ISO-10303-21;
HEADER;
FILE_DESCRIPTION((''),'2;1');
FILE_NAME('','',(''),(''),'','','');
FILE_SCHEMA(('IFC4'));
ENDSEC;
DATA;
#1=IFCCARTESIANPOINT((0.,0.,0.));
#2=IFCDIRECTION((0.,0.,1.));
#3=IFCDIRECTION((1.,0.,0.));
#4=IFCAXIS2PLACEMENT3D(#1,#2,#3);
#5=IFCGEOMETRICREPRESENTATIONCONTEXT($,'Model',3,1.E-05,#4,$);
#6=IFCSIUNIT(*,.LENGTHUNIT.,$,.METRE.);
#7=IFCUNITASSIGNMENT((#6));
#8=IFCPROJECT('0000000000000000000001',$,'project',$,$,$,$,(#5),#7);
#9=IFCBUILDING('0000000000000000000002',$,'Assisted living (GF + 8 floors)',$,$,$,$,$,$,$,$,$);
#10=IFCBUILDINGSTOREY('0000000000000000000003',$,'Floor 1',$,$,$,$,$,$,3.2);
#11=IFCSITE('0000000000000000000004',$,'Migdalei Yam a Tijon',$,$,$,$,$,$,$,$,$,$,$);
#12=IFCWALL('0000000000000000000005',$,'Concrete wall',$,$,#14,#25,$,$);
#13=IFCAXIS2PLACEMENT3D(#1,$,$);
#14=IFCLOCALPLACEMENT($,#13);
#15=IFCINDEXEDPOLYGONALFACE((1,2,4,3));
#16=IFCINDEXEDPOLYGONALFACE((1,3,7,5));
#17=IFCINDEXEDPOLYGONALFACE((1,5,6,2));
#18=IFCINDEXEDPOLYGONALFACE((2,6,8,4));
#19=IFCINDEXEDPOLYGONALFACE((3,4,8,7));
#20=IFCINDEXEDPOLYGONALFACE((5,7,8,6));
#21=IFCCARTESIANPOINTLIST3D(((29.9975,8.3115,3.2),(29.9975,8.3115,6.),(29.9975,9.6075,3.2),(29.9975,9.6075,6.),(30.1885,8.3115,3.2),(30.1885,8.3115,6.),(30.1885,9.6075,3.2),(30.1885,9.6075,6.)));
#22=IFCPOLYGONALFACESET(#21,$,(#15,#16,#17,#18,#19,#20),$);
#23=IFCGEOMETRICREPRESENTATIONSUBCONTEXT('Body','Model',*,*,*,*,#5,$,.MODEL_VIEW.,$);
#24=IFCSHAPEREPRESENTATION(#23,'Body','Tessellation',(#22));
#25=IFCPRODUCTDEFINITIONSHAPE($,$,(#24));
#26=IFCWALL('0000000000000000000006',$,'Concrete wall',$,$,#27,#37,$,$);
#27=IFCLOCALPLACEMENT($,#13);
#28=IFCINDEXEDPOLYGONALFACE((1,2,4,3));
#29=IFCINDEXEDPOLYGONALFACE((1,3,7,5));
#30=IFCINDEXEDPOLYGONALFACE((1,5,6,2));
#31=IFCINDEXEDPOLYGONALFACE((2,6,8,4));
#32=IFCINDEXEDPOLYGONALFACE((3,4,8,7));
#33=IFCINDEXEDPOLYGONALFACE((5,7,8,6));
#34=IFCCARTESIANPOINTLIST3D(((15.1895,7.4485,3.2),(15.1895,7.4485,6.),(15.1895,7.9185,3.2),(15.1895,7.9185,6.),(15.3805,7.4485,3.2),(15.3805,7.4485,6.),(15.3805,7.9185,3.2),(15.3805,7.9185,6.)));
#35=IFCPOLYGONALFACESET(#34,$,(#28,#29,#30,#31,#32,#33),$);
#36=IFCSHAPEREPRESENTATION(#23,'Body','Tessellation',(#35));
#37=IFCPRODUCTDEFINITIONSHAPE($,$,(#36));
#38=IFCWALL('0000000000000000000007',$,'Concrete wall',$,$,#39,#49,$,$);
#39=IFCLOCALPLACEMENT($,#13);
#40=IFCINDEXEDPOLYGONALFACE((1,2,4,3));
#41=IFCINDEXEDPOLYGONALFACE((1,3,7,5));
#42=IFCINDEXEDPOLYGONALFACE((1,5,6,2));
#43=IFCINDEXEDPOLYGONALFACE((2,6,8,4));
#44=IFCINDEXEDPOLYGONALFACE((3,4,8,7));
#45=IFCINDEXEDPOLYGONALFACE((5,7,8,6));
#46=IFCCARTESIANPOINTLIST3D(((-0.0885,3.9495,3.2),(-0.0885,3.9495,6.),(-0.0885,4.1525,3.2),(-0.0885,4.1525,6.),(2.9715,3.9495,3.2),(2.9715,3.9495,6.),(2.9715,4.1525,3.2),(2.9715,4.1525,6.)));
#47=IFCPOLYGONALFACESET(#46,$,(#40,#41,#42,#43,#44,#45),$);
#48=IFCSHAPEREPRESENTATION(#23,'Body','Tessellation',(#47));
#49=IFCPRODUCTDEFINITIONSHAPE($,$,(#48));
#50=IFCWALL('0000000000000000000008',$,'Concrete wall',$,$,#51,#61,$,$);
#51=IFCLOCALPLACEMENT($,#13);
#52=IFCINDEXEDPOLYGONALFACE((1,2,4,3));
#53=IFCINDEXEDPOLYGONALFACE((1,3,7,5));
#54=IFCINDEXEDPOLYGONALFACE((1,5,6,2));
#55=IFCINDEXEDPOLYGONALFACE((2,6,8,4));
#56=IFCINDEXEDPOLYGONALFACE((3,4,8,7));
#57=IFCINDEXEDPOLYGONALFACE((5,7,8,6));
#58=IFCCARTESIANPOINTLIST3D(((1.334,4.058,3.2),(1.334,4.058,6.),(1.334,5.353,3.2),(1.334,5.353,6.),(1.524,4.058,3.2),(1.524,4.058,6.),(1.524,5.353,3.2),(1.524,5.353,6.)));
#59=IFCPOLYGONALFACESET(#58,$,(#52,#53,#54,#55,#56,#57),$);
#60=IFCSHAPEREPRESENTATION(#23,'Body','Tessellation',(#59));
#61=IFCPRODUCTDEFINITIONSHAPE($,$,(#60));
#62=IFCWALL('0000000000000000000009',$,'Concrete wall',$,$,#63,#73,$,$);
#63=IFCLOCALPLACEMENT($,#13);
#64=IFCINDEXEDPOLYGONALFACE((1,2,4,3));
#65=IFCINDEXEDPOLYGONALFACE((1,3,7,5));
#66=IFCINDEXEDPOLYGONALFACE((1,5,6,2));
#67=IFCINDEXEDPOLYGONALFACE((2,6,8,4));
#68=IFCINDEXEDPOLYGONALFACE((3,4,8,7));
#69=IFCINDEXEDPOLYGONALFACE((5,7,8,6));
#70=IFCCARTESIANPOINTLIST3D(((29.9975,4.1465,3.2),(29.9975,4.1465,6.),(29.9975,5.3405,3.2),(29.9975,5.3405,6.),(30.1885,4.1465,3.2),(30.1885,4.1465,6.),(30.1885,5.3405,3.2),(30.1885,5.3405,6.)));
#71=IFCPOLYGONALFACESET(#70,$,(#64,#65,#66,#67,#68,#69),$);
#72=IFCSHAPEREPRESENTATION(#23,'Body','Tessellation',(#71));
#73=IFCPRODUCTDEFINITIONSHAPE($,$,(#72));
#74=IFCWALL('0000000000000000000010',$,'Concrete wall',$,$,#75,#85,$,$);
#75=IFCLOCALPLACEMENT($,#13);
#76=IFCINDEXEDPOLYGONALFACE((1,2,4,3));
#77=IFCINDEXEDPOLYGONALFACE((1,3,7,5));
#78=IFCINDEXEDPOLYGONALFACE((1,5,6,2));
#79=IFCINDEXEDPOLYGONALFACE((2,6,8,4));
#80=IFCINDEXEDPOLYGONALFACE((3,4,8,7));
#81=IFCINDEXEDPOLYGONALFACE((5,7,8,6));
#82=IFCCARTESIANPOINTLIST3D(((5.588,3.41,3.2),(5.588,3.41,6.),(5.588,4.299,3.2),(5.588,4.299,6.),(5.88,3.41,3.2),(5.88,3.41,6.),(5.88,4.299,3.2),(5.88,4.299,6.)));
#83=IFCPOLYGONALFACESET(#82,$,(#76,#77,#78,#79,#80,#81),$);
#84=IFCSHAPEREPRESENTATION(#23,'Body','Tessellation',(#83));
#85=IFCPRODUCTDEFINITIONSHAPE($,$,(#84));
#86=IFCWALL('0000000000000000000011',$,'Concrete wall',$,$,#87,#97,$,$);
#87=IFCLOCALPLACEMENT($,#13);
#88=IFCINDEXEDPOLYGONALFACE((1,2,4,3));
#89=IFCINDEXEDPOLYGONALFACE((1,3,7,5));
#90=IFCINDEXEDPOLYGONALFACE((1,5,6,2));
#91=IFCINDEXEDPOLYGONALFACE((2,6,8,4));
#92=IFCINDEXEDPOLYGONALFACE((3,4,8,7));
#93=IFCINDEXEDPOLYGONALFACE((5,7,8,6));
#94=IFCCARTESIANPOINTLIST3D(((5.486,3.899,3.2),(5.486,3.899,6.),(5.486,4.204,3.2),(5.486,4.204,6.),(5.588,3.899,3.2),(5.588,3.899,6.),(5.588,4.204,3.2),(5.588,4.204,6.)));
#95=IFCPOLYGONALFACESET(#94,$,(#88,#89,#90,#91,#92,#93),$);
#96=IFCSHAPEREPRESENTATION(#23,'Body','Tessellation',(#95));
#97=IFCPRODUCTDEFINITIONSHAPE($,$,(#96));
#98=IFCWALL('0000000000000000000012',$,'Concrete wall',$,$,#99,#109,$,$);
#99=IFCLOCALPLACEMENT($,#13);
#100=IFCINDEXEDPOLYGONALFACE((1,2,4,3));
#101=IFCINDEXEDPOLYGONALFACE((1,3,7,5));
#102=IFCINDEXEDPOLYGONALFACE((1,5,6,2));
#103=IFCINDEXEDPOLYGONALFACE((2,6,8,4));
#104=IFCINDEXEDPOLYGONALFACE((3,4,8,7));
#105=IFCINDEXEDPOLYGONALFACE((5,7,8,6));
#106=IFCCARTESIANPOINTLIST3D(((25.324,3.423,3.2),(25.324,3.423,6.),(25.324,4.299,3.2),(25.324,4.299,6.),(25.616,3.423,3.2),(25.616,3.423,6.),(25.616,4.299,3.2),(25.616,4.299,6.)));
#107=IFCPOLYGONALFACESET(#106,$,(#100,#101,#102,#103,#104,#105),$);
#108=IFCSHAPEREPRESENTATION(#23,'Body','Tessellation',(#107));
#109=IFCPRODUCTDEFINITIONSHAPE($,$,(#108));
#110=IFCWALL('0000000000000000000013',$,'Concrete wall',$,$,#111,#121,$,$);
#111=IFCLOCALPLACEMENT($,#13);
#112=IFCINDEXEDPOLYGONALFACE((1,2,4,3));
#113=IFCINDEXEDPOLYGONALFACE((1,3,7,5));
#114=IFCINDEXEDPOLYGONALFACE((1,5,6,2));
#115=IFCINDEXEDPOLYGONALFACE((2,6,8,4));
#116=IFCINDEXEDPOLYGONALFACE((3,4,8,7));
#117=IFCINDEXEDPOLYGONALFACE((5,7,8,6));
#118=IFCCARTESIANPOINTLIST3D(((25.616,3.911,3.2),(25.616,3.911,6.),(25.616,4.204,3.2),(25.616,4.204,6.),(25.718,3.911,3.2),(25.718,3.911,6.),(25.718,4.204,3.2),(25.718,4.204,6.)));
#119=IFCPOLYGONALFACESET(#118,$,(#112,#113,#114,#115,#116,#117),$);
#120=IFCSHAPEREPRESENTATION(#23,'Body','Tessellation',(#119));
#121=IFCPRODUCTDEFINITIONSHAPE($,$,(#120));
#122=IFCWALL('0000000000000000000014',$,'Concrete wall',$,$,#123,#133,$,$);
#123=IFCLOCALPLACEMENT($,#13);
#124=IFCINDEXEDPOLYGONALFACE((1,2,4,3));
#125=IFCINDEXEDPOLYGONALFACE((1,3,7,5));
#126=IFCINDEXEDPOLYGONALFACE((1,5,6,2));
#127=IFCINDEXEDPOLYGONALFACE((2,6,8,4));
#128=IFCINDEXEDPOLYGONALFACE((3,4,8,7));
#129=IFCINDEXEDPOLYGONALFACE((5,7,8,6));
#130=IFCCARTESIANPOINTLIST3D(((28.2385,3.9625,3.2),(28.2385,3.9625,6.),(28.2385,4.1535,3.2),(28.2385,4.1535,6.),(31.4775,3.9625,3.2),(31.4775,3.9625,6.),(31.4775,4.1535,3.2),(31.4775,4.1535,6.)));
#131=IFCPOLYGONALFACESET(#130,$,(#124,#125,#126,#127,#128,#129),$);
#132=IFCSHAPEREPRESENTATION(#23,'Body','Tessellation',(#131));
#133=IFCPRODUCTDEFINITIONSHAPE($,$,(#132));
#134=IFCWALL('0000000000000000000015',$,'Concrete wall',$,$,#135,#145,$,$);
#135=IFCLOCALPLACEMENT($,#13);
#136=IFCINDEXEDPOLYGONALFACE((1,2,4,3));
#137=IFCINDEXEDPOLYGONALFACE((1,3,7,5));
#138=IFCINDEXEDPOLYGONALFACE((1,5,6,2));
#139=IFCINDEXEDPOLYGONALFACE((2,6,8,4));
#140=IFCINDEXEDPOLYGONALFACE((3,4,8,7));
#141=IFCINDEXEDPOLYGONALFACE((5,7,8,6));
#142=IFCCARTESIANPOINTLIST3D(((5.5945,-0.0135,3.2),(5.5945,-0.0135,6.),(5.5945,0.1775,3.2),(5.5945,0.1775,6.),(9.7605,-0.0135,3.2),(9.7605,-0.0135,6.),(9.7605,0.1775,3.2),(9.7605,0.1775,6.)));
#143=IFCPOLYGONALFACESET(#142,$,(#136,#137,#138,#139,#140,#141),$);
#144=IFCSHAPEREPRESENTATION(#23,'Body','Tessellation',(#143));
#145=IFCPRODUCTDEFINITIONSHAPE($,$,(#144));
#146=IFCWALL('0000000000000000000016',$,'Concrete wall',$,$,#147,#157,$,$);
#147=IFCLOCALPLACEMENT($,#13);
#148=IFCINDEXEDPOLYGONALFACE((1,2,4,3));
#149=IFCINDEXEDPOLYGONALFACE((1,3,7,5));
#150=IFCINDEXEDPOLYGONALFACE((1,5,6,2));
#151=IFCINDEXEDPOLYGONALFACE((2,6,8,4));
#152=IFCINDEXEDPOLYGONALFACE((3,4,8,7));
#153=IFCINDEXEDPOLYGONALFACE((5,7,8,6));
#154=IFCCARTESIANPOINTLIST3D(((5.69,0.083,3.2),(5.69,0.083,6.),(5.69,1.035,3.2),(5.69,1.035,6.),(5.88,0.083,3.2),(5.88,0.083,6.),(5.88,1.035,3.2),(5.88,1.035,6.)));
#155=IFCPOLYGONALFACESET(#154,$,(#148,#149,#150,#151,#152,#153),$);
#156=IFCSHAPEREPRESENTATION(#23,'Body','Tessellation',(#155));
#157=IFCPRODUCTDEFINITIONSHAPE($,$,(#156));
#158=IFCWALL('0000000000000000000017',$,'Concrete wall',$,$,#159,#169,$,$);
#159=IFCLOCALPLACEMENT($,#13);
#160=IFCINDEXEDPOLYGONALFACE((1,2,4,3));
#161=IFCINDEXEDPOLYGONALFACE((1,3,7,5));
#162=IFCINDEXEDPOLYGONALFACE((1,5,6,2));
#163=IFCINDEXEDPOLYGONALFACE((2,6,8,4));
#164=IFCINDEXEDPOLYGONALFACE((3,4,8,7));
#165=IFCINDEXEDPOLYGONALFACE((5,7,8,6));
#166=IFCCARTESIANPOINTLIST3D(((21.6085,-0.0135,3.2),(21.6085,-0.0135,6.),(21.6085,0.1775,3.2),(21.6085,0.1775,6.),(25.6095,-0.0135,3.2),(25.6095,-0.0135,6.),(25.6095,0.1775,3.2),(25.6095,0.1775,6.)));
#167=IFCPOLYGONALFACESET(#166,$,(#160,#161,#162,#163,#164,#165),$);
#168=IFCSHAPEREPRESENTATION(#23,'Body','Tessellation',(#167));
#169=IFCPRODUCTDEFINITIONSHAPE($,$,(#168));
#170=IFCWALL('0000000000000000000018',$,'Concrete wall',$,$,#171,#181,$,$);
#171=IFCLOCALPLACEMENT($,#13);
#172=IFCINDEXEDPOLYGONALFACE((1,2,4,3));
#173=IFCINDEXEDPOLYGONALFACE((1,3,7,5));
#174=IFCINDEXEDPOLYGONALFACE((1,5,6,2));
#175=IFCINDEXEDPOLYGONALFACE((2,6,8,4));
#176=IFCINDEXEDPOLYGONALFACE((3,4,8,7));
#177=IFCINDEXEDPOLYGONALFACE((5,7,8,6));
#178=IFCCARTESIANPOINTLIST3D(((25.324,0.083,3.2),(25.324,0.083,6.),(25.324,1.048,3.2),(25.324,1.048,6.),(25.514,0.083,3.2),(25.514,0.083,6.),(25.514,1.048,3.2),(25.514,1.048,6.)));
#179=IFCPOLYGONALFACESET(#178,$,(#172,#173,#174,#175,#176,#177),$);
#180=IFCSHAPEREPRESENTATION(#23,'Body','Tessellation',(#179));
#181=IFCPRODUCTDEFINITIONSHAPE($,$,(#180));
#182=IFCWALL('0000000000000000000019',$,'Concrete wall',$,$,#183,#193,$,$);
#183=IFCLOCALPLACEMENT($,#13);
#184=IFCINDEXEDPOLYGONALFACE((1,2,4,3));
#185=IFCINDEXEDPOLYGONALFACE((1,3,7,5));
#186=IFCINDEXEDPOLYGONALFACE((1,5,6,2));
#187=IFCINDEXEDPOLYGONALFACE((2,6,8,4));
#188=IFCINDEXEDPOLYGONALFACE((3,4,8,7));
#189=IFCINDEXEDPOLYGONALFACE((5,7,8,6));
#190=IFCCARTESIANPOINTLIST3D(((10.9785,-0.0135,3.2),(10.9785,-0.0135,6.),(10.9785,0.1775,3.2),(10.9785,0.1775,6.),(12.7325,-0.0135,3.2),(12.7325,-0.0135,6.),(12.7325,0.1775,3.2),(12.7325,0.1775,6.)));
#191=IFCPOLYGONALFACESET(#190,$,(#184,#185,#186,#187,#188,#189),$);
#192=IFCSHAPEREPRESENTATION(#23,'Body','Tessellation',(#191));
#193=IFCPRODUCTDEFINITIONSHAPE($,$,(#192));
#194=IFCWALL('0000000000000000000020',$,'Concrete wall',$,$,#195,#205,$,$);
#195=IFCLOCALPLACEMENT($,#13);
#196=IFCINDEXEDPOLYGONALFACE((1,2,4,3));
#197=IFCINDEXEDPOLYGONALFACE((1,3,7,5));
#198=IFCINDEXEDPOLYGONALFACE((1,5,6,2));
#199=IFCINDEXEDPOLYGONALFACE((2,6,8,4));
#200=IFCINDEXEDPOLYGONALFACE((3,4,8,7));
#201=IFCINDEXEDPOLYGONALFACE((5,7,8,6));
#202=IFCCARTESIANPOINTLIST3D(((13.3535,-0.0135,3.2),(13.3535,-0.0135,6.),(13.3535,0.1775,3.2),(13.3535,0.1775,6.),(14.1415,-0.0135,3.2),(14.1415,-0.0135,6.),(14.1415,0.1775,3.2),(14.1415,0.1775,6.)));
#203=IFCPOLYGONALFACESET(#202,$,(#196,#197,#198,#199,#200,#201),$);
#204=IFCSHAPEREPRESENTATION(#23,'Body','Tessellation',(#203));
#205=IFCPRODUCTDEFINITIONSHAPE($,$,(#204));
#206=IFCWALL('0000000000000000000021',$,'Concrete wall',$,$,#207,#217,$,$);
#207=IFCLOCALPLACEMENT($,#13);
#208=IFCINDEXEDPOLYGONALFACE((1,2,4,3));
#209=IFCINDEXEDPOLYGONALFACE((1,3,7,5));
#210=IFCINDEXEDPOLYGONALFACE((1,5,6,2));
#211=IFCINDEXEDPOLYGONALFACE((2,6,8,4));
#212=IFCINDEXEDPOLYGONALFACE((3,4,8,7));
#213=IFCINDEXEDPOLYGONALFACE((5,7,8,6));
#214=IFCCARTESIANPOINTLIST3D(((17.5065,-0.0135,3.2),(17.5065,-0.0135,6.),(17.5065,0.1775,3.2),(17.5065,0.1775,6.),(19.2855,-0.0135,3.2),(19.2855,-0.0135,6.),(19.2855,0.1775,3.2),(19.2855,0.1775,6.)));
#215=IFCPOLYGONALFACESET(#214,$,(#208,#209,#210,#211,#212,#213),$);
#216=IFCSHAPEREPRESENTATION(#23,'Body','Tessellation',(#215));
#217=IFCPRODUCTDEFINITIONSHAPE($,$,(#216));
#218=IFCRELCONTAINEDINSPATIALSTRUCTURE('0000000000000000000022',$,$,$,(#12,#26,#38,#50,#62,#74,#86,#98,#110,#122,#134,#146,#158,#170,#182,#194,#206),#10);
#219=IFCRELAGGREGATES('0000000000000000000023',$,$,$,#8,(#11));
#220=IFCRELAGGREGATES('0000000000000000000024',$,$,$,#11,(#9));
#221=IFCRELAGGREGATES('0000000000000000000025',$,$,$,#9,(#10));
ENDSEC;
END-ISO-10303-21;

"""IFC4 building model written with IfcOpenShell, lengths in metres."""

from ifc_helpers import new_model, si_unit, frame, origin_with_axes, context, subcontext, project, spatial, line, indexed_curve, outline, extrude, element, save


model = new_model("IFC4")

# Units and contexts
model_context = context("Model", 3, precision=1e-05, world=origin_with_axes())
body_context = subcontext(model_context, "Body", "Model", "MODEL_VIEW")
ifc_project = project(units=[si_unit("LENGTHUNIT", "METRE")], contexts=[model_context])

# Site, building, storey
site = spatial("IfcSite", under=ifc_project, Name="Migdalei Yam a Tijon")
building = spatial("IfcBuilding", under=site, Name="Assisted living (GF + 8 floors)")
storey = spatial("IfcBuildingStorey", under=building, Name="Floor 1", Elevation=3.2)

# Walls
element("IfcWall", 1, inside=storey, Name="Concrete wall", context=body_context, shape_type="SweptSolid", body=[
    extrude(outline(indexed_curve([(0.0, 0.0), (0.191, 0.0), (0.191, 1.296), (0.0, 1.296)], segments=[line(1, 2, 3, 4, 1)])), frame((29.9975, 8.3115, 3.2), z_axis=(0.0, 0.0, 1.0), x_axis=(1.0, 0.0, 0.0)), (0.0, 0.0, 1.0), 2.8),
])
element("IfcWall", 2, inside=storey, Name="Concrete wall", context=body_context, shape_type="SweptSolid", body=[
    extrude(outline(indexed_curve([(0.0, 0.0), (0.191, 0.0), (0.191, 0.47), (0.0, 0.47)], segments=[line(1, 2, 3, 4, 1)])), frame((15.1895, 7.4485, 3.2), z_axis=(0.0, 0.0, 1.0), x_axis=(1.0, 0.0, 0.0)), (0.0, 0.0, 1.0), 2.8),
])
element("IfcWall", 3, inside=storey, Name="Concrete wall", context=body_context, shape_type="SweptSolid", body=[
    extrude(outline(indexed_curve([(0.0, 0.0), (3.06, 0.0), (3.06, 0.203), (0.0, 0.203)], segments=[line(1, 2, 3, 4, 1)])), frame((-0.0885, 3.9495, 3.2), z_axis=(0.0, 0.0, 1.0), x_axis=(1.0, 0.0, 0.0)), (0.0, 0.0, 1.0), 2.8),
])
element("IfcWall", 4, inside=storey, Name="Concrete wall", context=body_context, shape_type="SweptSolid", body=[
    extrude(outline(indexed_curve([(0.0, 0.0), (0.19, 0.0), (0.19, 1.295), (0.0, 1.295)], segments=[line(1, 2, 3, 4, 1)])), frame((1.334, 4.058, 3.2), z_axis=(0.0, 0.0, 1.0), x_axis=(1.0, 0.0, 0.0)), (0.0, 0.0, 1.0), 2.8),
])
element("IfcWall", 5, inside=storey, Name="Concrete wall", context=body_context, shape_type="SweptSolid", body=[
    extrude(outline(indexed_curve([(0.0, 0.0), (0.191, 0.0), (0.191, 1.194), (0.0, 1.194)], segments=[line(1, 2, 3, 4, 1)])), frame((29.9975, 4.1465, 3.2), z_axis=(0.0, 0.0, 1.0), x_axis=(1.0, 0.0, 0.0)), (0.0, 0.0, 1.0), 2.8),
])
element("IfcWall", 6, inside=storey, Name="Concrete wall", context=body_context, shape_type="SweptSolid", body=[
    extrude(outline(indexed_curve([(0.0, 0.0), (0.292, 0.0), (0.292, 0.889), (0.0, 0.889)], segments=[line(1, 2, 3, 4, 1)])), frame((5.588, 3.41, 3.2), z_axis=(0.0, 0.0, 1.0), x_axis=(1.0, 0.0, 0.0)), (0.0, 0.0, 1.0), 2.8),
])
element("IfcWall", 7, inside=storey, Name="Concrete wall", context=body_context, shape_type="SweptSolid", body=[
    extrude(outline(indexed_curve([(0.0, 0.0), (0.102, 0.0), (0.102, 0.305), (0.0, 0.305)], segments=[line(1, 2, 3, 4, 1)])), frame((5.486, 3.899, 3.2), z_axis=(0.0, 0.0, 1.0), x_axis=(1.0, 0.0, 0.0)), (0.0, 0.0, 1.0), 2.8),
])
element("IfcWall", 8, inside=storey, Name="Concrete wall", context=body_context, shape_type="SweptSolid", body=[
    extrude(outline(indexed_curve([(0.0, 0.0), (0.292, 0.0), (0.292, 0.876), (0.0, 0.876)], segments=[line(1, 2, 3, 4, 1)])), frame((25.324, 3.423, 3.2), z_axis=(0.0, 0.0, 1.0), x_axis=(1.0, 0.0, 0.0)), (0.0, 0.0, 1.0), 2.8),
])
element("IfcWall", 9, inside=storey, Name="Concrete wall", context=body_context, shape_type="SweptSolid", body=[
    extrude(outline(indexed_curve([(0.0, 0.0), (0.102, 0.0), (0.102, 0.293), (0.0, 0.293)], segments=[line(1, 2, 3, 4, 1)])), frame((25.616, 3.911, 3.2), z_axis=(0.0, 0.0, 1.0), x_axis=(1.0, 0.0, 0.0)), (0.0, 0.0, 1.0), 2.8),
])
element("IfcWall", 10, inside=storey, Name="Concrete wall", context=body_context, shape_type="SweptSolid", body=[
    extrude(outline(indexed_curve([(0.0, 0.0), (3.239, 0.0), (3.239, 0.191), (0.0, 0.191)], segments=[line(1, 2, 3, 4, 1)])), frame((28.2385, 3.9625, 3.2), z_axis=(0.0, 0.0, 1.0), x_axis=(1.0, 0.0, 0.0)), (0.0, 0.0, 1.0), 2.8),
])
element("IfcWall", 11, inside=storey, Name="Concrete wall", context=body_context, shape_type="SweptSolid", body=[
    extrude(outline(indexed_curve([(0.0, 0.0), (4.166, 0.0), (4.166, 0.191), (0.0, 0.191)], segments=[line(1, 2, 3, 4, 1)])), frame((5.5945, -0.0135, 3.2), z_axis=(0.0, 0.0, 1.0), x_axis=(1.0, 0.0, 0.0)), (0.0, 0.0, 1.0), 2.8),
])
element("IfcWall", 12, inside=storey, Name="Concrete wall", context=body_context, shape_type="SweptSolid", body=[
    extrude(outline(indexed_curve([(0.0, 0.0), (0.19, 0.0), (0.19, 0.952), (0.0, 0.952)], segments=[line(1, 2, 3, 4, 1)])), frame((5.69, 0.083, 3.2), z_axis=(0.0, 0.0, 1.0), x_axis=(1.0, 0.0, 0.0)), (0.0, 0.0, 1.0), 2.8),
])
element("IfcWall", 13, inside=storey, Name="Concrete wall", context=body_context, shape_type="SweptSolid", body=[
    extrude(outline(indexed_curve([(0.0, 0.0), (4.001, 0.0), (4.001, 0.191), (0.0, 0.191)], segments=[line(1, 2, 3, 4, 1)])), frame((21.6085, -0.0135, 3.2), z_axis=(0.0, 0.0, 1.0), x_axis=(1.0, 0.0, 0.0)), (0.0, 0.0, 1.0), 2.8),
])
element("IfcWall", 14, inside=storey, Name="Concrete wall", context=body_context, shape_type="SweptSolid", body=[
    extrude(outline(indexed_curve([(0.0, 0.0), (0.19, 0.0), (0.19, 0.965), (0.0, 0.965)], segments=[line(1, 2, 3, 4, 1)])), frame((25.324, 0.083, 3.2), z_axis=(0.0, 0.0, 1.0), x_axis=(1.0, 0.0, 0.0)), (0.0, 0.0, 1.0), 2.8),
])
element("IfcWall", 15, inside=storey, Name="Concrete wall", context=body_context, shape_type="SweptSolid", body=[
    extrude(outline(indexed_curve([(0.0, 0.0), (1.754, 0.0), (1.754, 0.191), (0.0, 0.191)], segments=[line(1, 2, 3, 4, 1)])), frame((10.9785, -0.0135, 3.2), z_axis=(0.0, 0.0, 1.0), x_axis=(1.0, 0.0, 0.0)), (0.0, 0.0, 1.0), 2.8),
])
element("IfcWall", 16, inside=storey, Name="Concrete wall", context=body_context, shape_type="SweptSolid", body=[
    extrude(outline(indexed_curve([(0.0, 0.0), (0.788, 0.0), (0.788, 0.191), (0.0, 0.191)], segments=[line(1, 2, 3, 4, 1)])), frame((13.3535, -0.0135, 3.2), z_axis=(0.0, 0.0, 1.0), x_axis=(1.0, 0.0, 0.0)), (0.0, 0.0, 1.0), 2.8),
])
element("IfcWall", 17, inside=storey, Name="Concrete wall", context=body_context, shape_type="SweptSolid", body=[
    extrude(outline(indexed_curve([(0.0, 0.0), (1.779, 0.0), (1.779, 0.191), (0.0, 0.191)], segments=[line(1, 2, 3, 4, 1)])), frame((17.5065, -0.0135, 3.2), z_axis=(0.0, 0.0, 1.0), x_axis=(1.0, 0.0, 0.0)), (0.0, 0.0, 1.0), 2.8),
])

save(model, "model.ifc")
